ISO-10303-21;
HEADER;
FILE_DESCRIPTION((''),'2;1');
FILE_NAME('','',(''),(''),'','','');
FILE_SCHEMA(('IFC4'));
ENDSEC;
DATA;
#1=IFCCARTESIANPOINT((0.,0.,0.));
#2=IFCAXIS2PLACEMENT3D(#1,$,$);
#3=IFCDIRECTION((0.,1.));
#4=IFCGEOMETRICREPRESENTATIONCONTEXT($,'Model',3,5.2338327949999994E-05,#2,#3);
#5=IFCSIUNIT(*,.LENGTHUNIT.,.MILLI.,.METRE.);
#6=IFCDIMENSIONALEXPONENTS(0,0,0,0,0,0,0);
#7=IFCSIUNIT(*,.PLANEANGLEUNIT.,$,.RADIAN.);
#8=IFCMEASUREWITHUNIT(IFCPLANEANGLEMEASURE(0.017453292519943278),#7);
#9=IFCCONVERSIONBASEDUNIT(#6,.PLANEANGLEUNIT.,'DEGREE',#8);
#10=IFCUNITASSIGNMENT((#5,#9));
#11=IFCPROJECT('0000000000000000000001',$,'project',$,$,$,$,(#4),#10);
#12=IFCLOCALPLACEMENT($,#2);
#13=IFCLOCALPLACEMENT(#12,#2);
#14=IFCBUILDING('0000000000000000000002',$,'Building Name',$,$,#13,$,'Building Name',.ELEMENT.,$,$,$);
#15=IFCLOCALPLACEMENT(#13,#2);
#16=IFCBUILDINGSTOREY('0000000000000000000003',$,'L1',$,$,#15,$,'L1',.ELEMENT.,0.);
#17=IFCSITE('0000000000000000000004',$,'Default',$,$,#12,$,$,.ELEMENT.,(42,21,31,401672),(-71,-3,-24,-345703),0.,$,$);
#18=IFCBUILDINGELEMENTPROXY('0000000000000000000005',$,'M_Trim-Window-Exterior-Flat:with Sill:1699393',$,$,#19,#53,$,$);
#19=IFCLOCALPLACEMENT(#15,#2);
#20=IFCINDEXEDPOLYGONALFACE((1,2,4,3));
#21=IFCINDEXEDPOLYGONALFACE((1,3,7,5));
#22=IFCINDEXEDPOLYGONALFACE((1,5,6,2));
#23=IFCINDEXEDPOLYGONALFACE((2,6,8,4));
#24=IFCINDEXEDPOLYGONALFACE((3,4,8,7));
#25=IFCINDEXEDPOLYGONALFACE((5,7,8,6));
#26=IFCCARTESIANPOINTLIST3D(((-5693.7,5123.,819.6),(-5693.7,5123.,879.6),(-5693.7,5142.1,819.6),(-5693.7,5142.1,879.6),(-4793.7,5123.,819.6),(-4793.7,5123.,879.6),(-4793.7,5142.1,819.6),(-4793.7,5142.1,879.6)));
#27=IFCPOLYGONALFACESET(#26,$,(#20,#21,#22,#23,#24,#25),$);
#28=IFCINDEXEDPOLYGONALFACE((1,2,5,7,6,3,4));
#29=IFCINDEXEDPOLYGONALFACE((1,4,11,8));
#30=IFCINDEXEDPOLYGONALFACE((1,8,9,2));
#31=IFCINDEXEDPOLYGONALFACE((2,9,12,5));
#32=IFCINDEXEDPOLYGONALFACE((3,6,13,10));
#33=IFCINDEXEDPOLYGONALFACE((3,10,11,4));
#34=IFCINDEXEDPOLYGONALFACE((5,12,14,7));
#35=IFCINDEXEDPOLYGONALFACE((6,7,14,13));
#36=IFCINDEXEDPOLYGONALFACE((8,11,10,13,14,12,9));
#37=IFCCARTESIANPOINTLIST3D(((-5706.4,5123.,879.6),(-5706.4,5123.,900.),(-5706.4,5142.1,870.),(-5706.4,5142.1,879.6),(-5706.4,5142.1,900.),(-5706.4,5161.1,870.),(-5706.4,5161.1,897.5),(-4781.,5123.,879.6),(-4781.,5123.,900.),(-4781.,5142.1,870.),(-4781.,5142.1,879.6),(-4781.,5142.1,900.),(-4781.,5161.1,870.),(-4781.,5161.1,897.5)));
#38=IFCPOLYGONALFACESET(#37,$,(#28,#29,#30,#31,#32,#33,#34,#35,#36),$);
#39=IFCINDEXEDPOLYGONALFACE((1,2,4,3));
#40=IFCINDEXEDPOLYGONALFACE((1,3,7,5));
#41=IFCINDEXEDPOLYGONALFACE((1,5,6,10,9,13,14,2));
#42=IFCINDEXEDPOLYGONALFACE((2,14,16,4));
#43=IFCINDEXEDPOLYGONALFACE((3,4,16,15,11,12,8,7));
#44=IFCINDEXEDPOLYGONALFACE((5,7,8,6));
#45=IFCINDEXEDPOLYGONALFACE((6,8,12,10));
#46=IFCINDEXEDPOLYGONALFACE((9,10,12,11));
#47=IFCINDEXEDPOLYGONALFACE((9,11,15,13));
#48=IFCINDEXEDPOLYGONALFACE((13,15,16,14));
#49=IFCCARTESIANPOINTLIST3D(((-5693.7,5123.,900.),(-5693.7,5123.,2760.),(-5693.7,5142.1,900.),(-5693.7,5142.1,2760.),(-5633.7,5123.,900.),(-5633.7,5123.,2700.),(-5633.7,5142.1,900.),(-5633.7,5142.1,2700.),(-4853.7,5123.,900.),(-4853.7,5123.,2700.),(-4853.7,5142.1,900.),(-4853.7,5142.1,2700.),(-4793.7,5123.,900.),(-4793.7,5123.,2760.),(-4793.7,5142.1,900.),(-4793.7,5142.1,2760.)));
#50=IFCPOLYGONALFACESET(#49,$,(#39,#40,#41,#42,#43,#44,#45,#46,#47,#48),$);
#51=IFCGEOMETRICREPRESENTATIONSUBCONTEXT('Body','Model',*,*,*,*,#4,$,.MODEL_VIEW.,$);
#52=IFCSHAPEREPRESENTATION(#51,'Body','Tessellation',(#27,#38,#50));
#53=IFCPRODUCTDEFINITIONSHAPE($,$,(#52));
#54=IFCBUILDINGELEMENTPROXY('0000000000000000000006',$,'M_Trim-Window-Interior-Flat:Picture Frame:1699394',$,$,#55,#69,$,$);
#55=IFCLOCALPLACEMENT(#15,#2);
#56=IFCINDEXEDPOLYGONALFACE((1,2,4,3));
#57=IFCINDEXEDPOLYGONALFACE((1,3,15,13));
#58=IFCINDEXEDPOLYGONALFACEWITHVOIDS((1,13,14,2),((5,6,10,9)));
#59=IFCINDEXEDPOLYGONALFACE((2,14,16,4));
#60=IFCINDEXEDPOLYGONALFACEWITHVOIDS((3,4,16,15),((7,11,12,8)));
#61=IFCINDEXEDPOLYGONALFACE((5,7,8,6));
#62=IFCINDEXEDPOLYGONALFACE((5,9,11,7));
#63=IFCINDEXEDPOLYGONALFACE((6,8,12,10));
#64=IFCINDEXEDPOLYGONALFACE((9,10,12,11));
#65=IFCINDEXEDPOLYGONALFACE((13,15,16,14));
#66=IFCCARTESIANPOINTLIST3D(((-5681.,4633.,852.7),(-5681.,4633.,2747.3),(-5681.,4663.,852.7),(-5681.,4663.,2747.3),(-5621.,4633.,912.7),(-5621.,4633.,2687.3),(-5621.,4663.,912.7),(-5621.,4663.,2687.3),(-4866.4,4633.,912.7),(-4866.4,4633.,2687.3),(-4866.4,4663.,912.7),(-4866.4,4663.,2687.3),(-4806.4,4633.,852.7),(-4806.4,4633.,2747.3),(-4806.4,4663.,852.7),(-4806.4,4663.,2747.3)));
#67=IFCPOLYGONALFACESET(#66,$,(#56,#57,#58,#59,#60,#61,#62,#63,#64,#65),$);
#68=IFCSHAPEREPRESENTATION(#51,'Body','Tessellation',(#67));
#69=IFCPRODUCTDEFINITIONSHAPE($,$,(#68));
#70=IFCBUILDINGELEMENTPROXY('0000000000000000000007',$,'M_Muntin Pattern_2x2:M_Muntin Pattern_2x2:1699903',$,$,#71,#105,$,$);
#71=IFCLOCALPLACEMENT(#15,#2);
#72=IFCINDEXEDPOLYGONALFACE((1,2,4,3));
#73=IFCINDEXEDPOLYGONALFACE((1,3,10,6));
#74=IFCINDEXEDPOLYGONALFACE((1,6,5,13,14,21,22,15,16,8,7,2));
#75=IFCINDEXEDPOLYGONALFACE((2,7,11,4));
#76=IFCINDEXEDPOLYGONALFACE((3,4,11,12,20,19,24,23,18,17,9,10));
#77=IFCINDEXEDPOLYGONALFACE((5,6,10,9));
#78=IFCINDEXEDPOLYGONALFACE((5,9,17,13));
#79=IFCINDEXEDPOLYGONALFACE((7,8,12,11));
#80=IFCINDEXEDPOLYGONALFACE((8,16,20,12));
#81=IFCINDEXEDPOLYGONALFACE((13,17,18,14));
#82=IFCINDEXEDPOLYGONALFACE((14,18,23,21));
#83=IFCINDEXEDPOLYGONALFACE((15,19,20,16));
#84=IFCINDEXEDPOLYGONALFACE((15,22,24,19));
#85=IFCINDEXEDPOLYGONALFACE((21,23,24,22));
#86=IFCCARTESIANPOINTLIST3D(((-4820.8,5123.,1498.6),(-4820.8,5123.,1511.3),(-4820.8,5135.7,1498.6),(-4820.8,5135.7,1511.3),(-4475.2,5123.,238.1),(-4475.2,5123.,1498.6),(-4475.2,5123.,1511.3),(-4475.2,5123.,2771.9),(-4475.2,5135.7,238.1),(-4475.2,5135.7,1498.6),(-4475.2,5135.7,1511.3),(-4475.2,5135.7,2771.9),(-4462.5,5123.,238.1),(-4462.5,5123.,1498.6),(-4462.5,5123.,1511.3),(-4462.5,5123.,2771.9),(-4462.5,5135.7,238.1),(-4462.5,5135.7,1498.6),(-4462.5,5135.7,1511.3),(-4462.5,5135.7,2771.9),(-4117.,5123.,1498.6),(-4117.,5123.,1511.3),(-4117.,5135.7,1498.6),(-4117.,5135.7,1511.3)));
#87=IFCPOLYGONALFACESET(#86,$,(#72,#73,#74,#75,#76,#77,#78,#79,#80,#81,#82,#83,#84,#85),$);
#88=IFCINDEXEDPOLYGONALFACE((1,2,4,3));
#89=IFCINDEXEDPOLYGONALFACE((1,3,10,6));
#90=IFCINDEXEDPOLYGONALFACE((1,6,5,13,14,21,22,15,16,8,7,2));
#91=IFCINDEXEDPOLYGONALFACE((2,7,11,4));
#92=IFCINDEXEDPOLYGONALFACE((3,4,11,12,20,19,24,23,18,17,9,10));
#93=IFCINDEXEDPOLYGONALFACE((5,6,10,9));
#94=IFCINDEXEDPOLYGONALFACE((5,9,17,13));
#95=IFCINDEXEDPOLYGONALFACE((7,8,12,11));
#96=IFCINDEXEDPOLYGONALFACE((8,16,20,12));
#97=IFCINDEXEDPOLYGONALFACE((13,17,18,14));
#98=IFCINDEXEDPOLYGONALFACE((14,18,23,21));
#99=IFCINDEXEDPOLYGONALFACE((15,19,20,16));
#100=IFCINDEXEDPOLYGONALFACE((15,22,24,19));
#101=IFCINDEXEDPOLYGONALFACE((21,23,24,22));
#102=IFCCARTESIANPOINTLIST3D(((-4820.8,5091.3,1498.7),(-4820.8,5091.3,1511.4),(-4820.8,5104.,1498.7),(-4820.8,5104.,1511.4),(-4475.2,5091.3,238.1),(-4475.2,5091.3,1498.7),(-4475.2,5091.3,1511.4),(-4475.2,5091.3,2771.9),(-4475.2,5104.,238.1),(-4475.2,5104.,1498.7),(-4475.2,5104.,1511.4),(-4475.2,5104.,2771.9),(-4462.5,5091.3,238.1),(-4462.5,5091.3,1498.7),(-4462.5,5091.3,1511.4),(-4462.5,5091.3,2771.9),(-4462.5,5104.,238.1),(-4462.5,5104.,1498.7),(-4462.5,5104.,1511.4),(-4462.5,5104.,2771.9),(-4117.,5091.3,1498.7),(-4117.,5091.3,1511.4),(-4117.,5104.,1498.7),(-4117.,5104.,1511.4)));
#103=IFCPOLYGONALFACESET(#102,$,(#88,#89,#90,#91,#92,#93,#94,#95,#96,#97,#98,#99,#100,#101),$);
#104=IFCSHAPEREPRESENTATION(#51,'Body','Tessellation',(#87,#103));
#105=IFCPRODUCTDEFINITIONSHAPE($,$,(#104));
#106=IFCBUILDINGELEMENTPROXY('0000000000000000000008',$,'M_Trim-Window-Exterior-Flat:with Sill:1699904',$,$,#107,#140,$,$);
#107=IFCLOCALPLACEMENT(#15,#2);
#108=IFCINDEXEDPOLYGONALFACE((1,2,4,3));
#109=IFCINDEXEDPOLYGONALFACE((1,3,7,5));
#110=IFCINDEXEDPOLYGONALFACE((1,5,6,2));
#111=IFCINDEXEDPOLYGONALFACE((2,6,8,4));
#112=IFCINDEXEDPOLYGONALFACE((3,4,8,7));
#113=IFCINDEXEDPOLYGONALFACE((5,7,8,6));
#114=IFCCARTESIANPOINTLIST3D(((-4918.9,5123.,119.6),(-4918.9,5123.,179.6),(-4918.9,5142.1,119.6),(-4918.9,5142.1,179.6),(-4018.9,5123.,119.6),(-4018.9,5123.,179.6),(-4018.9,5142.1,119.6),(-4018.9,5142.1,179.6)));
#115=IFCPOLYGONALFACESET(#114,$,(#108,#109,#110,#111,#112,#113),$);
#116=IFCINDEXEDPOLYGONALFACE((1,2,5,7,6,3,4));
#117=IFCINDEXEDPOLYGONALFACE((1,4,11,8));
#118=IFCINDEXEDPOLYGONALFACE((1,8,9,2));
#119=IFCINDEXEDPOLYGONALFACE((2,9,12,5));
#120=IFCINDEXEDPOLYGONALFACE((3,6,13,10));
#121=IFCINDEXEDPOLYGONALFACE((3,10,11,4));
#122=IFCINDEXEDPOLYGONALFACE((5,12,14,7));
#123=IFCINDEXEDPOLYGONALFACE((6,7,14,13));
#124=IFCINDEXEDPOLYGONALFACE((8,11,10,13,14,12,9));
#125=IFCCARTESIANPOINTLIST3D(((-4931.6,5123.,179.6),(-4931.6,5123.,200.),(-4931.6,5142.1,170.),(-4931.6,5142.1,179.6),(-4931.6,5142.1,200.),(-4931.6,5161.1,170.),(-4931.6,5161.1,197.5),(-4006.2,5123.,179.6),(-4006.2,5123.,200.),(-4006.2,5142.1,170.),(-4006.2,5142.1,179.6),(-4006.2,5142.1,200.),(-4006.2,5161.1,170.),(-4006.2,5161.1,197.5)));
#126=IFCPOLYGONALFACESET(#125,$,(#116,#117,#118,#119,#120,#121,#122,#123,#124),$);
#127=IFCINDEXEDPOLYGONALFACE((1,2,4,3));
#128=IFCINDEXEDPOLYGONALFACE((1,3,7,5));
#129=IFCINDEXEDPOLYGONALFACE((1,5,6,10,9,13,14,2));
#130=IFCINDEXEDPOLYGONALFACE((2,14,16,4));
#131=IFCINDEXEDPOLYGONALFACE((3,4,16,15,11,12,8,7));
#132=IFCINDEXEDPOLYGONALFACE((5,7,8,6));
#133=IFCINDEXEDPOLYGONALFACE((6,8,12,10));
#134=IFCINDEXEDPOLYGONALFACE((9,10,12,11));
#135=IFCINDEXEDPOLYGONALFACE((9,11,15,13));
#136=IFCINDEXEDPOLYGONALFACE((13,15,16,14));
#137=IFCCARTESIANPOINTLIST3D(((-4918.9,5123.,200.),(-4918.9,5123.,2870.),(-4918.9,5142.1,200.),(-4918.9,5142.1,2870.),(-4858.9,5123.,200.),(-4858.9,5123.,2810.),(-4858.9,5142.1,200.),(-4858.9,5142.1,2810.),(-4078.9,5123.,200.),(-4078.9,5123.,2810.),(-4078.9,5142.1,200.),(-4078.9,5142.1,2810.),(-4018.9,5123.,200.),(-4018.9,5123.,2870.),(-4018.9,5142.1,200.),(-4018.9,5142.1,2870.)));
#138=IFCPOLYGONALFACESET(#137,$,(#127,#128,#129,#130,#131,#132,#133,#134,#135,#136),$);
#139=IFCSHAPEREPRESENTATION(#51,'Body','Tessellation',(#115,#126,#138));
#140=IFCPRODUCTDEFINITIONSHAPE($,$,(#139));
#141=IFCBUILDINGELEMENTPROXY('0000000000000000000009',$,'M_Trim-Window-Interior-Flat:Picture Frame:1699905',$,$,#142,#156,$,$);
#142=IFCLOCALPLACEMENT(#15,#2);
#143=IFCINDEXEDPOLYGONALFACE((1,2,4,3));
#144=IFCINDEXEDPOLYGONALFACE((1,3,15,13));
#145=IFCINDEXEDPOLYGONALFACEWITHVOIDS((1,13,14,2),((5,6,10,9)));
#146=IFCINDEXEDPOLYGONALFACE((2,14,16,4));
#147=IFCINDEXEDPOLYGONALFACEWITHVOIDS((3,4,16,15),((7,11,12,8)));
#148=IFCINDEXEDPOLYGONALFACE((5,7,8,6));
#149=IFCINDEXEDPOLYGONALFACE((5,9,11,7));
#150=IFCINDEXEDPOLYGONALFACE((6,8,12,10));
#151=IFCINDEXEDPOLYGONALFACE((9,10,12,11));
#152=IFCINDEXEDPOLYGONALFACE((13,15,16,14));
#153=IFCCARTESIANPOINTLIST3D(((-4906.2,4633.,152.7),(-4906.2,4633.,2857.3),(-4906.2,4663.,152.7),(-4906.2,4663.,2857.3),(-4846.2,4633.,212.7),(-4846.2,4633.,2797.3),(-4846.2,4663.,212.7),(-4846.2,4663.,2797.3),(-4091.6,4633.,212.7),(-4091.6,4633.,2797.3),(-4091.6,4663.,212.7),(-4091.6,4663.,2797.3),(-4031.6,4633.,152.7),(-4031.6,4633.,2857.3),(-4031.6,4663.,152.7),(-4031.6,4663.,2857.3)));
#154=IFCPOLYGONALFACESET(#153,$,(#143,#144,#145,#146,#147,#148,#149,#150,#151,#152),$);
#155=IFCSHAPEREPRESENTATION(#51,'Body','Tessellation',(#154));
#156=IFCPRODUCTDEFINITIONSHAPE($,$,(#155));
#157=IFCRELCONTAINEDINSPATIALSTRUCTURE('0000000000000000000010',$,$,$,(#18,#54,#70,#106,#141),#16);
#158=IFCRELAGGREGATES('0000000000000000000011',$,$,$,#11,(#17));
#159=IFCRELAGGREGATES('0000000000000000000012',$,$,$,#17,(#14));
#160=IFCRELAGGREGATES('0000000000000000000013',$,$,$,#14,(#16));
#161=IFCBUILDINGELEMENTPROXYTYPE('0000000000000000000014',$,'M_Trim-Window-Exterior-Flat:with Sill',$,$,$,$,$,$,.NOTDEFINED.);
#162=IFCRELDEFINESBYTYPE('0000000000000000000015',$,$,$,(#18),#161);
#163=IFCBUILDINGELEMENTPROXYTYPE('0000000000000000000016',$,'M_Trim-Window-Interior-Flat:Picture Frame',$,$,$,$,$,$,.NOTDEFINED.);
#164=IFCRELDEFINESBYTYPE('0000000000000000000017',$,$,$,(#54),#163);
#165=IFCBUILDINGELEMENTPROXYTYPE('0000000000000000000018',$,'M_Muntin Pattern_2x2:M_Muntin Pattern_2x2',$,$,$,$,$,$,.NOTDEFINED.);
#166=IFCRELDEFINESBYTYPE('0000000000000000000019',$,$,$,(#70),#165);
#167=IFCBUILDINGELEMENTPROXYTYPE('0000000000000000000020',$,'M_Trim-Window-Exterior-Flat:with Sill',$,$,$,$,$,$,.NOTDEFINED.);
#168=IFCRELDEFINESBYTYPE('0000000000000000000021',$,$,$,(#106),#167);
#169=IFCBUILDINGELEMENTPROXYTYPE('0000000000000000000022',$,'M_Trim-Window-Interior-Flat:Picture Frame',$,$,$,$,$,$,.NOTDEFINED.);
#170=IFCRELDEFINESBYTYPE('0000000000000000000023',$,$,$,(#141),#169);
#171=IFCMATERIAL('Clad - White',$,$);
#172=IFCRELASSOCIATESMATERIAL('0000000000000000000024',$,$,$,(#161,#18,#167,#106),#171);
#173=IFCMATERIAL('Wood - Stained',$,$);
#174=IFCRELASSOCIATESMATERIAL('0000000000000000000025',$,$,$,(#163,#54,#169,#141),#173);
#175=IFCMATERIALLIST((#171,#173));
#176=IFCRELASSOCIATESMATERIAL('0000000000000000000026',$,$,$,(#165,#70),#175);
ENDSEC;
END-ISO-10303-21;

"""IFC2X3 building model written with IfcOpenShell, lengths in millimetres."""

from ifc_helpers import new_model, entity, si_unit, converted_unit, direction, frame, frame_2d, origin, place, context, subcontext, project, spatial, polyline, rectangle, outline, extrude, source, transform, mapped, material, material_list, type_object, type_shapes, element, save


model = new_model("IFC2X3")

# Units and contexts
model_context = context("Model", 3, precision=5.2338327949999994e-05, world=origin(), true_north=direction((0.0, 1.0)))
body_context = subcontext(model_context, "Body", "Model", "MODEL_VIEW")
ifc_project = project(units=[si_unit("LENGTHUNIT", "METRE", prefix="MILLI"), converted_unit("PLANEANGLEUNIT", "DEGREE", entity("IfcPlaneAngleMeasure", 0.017453292519943278), si_unit("PLANEANGLEUNIT", "RADIAN"), dimensions=[0, 0, 0, 0, 0, 0, 0])], contexts=[model_context])

# Site, building, storey
site_placement = place(None, origin())
site = spatial("IfcSite", under=ifc_project, at=site_placement, Name="Default", CompositionType="ELEMENT", RefLatitude=(42, 21, 31, 401672), RefLongitude=(-71, -3, -24, -345703), RefElevation=0.0)
building_placement = place(site_placement, origin())
building = spatial("IfcBuilding", under=site, at=building_placement, Name="Building Name", LongName="Building Name", CompositionType="ELEMENT")
storey_placement = place(building_placement, origin())
storey = spatial("IfcBuildingStorey", under=building, at=storey_placement, Name="L1", LongName="L1", CompositionType="ELEMENT", Elevation=0.0)

# Building element proxies
ifc_material_1 = material(Name="Clad - White")
ifc_material_2 = material(Name="Wood - Stained")
ifc_material_list = material_list([ifc_material_1, ifc_material_2])
building_element_proxy_type_1 = type_object("IfcBuildingElementProxyType", Name="M_Trim-Window-Exterior-Flat:with Sill", PredefinedType="NOTDEFINED", material=ifc_material_1)
shared_shape_1 = source(origin(), body_context, "Body", "SweptSolid", [
    extrude(rectangle(XDim=60.0, YDim=900.0, at=frame_2d((0.0, 0.0), x_axis=(1.0, 0.0))), frame((0.0, 1850.4, 0.0), z_axis=(0.0, 0.0, 1.0), x_axis=(0.0, 1.0, 0.0)), (0.0, 0.0, 1.0), 19.0),
    extrude(outline(polyline([(-15.2, -19.0), (12.3, -19.0), (14.8, 0.0), (14.8, 19.0), (-5.7, 19.0), (-5.7, 0.0), (-15.2, 0.0), (-15.2, -19.0)])), frame((-462.7, 1814.8, 19.0), z_axis=(1.0, 0.0, 0.0), x_axis=(0.0, -1.0, 0.0)), (0.0, 0.0, 1.0), 925.4),
    extrude(outline(polyline([(-450.0, -945.0), (450.0, -945.0), (450.0, 915.0), (390.0, 915.0), (390.0, -885.0), (-390.0, -885.0), (-390.0, 915.0), (-450.0, 915.0), (-450.0, -945.0)])), frame((0.0, 885.0, 0.0)), (0.0, 0.0, 1.0), 19.0),
])
type_shapes(building_element_proxy_type_1, [shared_shape_1])
proxy_1_placement = place(storey_placement, frame((-5243.7, 5123.0, 2700.0), z_axis=(0.0, 1.0, 0.0), x_axis=(1.0, 0.0, 0.0)))
element("IfcBuildingElementProxy", 1, at=proxy_1_placement, inside=storey, type_object=building_element_proxy_type_1, material=ifc_material_1, Name="M_Trim-Window-Exterior-Flat:with Sill:1699393", context=body_context, shape_type="MappedRepresentation", body=[
    mapped(shared_shape_1, transform((0.0, 0.0, 0.0), scale=1.0)),
])
building_element_proxy_type_2 = type_object("IfcBuildingElementProxyType", Name="M_Trim-Window-Interior-Flat:Picture Frame", PredefinedType="NOTDEFINED", material=ifc_material_2)
shared_shape_2 = source(origin(), body_context, "Body", "SweptSolid", [
    extrude(outline(polyline([(-947.3, -437.3), (947.3, -437.3), (947.3, 437.3), (-947.3, 437.3), (-947.3, -437.3)]), holes=[polyline([(-887.3, -377.3), (-887.3, 377.3), (887.3, 377.3), (887.3, -377.3), (-887.3, -377.3)])]), frame((0.0, 900.0, 0.0), z_axis=(0.0, 0.0, 1.0), x_axis=(0.0, 1.0, 0.0)), (0.0, 0.0, 1.0), 30.0),
])
type_shapes(building_element_proxy_type_2, [shared_shape_2])
proxy_2_placement = place(storey_placement, frame((-5243.7, 4663.0, 2700.0), z_axis=(0.0, -1.0, 0.0), x_axis=(-1.0, 0.0, 0.0)))
element("IfcBuildingElementProxy", 2, at=proxy_2_placement, inside=storey, type_object=building_element_proxy_type_2, material=ifc_material_2, Name="M_Trim-Window-Interior-Flat:Picture Frame:1699394", context=body_context, shape_type="MappedRepresentation", body=[
    mapped(shared_shape_2, transform((0.0, 0.0, 0.0), scale=1.0)),
])
building_element_proxy_type_3 = type_object("IfcBuildingElementProxyType", Name="M_Muntin Pattern_2x2:M_Muntin Pattern_2x2", PredefinedType="NOTDEFINED", material=ifc_material_list)
shared_shape_3 = source(origin(), body_context, "Body", "SweptSolid", [
    extrude(outline(polyline([(6.4, -6.4), (1266.9, -6.4), (1266.9, 6.3), (6.4, 6.3), (6.4, 351.9), (-6.3, 351.9), (-6.3, 6.3), (-1266.9, 6.3), (-1266.9, -6.4), (-6.3, -6.4), (-6.3, -351.9), (6.4, -351.9), (6.4, -6.4)])), frame((0.0, -22.2, 1266.9), z_axis=(0.0, 1.0, 0.0), x_axis=(0.0, 0.0, 1.0)), (0.0, 0.0, 1.0), 12.7),
    extrude(outline(polyline([(6.4, -6.4), (1266.9, -6.4), (1266.9, 6.3), (6.4, 6.3), (6.4, 351.9), (-6.3, 351.9), (-6.3, 6.3), (-1266.9, 6.3), (-1266.9, -6.4), (-6.3, -6.4), (-6.3, -351.9), (6.4, -351.9), (6.4, -6.4)])), frame((0.0, 9.5, 1266.9), z_axis=(0.0, 1.0, 0.0), x_axis=(0.0, 0.0, 1.0)), (0.0, 0.0, 1.0), 12.7),
])
type_shapes(building_element_proxy_type_3, [shared_shape_3])
proxy_3_placement = place(storey_placement, frame((-4468.9, 5113.5, 238.1), z_axis=(0.0, 0.0, 1.0), x_axis=(-1.0, 0.0, 0.0)))
element("IfcBuildingElementProxy", 3, at=proxy_3_placement, inside=storey, type_object=building_element_proxy_type_3, material=ifc_material_list, Name="M_Muntin Pattern_2x2:M_Muntin Pattern_2x2:1699903", context=body_context, shape_type="MappedRepresentation", body=[
    mapped(shared_shape_3, transform((0.0, 0.0, 0.0), scale=1.0)),
])
building_element_proxy_type_4 = type_object("IfcBuildingElementProxyType", Name="M_Trim-Window-Exterior-Flat:with Sill", PredefinedType="NOTDEFINED", material=ifc_material_1)
shared_shape_4 = source(origin(), body_context, "Body", "SweptSolid", [
    extrude(rectangle(XDim=900.0, YDim=60.0, at=frame_2d((0.0, 0.0), x_axis=(1.0, 0.0))), frame((0.0, -2660.4, 0.0), z_axis=(0.0, 0.0, 1.0), x_axis=(-1.0, 0.0, 0.0)), (0.0, 0.0, 1.0), 19.0),
    extrude(outline(polyline([(-19.0, -15.2), (0.0, -15.2), (0.0, -5.7), (19.0, -5.7), (19.0, 14.8), (0.0, 14.8), (-19.0, 12.3), (-19.0, -15.2)])), frame((-462.7, -2624.8, 19.0), z_axis=(1.0, 0.0, 0.0), x_axis=(0.0, 0.0, -1.0)), (0.0, 0.0, 1.0), 925.4),
    extrude(outline(polyline([(-1350.0, -450.0), (1320.0, -450.0), (1320.0, -390.0), (-1290.0, -390.0), (-1290.0, 390.0), (1320.0, 390.0), (1320.0, 450.0), (-1350.0, 450.0), (-1350.0, -450.0)])), frame((0.0, -1290.0, 0.0), z_axis=(0.0, 0.0, 1.0), x_axis=(0.0, -1.0, 0.0)), (0.0, 0.0, 1.0), 19.0),
])
type_shapes(building_element_proxy_type_4, [shared_shape_4])
proxy_4_placement = place(storey_placement, frame((-4468.9, 5123.0, 2810.0), z_axis=(0.0, 1.0, 0.0), x_axis=(-1.0, 0.0, 0.0)))
element("IfcBuildingElementProxy", 4, at=proxy_4_placement, inside=storey, type_object=building_element_proxy_type_4, material=ifc_material_1, Name="M_Trim-Window-Exterior-Flat:with Sill:1699904", context=body_context, shape_type="MappedRepresentation", body=[
    mapped(shared_shape_4, transform((0.0, 0.0, 0.0), scale=1.0)),
])
building_element_proxy_type_5 = type_object("IfcBuildingElementProxyType", Name="M_Trim-Window-Interior-Flat:Picture Frame", PredefinedType="NOTDEFINED", material=ifc_material_2)
shared_shape_5 = source(origin(), body_context, "Body", "SweptSolid", [
    extrude(outline(polyline([(-437.3, -1352.3), (437.3, -1352.3), (437.3, 1352.3), (-437.3, 1352.3), (-437.3, -1352.3)]), holes=[polyline([(-377.3, -1292.3), (-377.3, 1292.3), (377.3, 1292.3), (377.3, -1292.3), (-377.3, -1292.3)])]), frame((0.0, -1305.0, 0.0), z_axis=(0.0, 0.0, 1.0), x_axis=(-1.0, 0.0, 0.0)), (0.0, 0.0, 1.0), 30.0),
])
type_shapes(building_element_proxy_type_5, [shared_shape_5])
proxy_5_placement = place(storey_placement, frame((-4468.9, 4663.0, 2810.0), z_axis=(0.0, -1.0, 0.0), x_axis=(1.0, 0.0, 0.0)))
element("IfcBuildingElementProxy", 5, at=proxy_5_placement, inside=storey, type_object=building_element_proxy_type_5, material=ifc_material_2, Name="M_Trim-Window-Interior-Flat:Picture Frame:1699905", context=body_context, shape_type="MappedRepresentation", body=[
    mapped(shared_shape_5, transform((0.0, 0.0, 0.0), scale=1.0)),
])

save(model, "model.ifc")
